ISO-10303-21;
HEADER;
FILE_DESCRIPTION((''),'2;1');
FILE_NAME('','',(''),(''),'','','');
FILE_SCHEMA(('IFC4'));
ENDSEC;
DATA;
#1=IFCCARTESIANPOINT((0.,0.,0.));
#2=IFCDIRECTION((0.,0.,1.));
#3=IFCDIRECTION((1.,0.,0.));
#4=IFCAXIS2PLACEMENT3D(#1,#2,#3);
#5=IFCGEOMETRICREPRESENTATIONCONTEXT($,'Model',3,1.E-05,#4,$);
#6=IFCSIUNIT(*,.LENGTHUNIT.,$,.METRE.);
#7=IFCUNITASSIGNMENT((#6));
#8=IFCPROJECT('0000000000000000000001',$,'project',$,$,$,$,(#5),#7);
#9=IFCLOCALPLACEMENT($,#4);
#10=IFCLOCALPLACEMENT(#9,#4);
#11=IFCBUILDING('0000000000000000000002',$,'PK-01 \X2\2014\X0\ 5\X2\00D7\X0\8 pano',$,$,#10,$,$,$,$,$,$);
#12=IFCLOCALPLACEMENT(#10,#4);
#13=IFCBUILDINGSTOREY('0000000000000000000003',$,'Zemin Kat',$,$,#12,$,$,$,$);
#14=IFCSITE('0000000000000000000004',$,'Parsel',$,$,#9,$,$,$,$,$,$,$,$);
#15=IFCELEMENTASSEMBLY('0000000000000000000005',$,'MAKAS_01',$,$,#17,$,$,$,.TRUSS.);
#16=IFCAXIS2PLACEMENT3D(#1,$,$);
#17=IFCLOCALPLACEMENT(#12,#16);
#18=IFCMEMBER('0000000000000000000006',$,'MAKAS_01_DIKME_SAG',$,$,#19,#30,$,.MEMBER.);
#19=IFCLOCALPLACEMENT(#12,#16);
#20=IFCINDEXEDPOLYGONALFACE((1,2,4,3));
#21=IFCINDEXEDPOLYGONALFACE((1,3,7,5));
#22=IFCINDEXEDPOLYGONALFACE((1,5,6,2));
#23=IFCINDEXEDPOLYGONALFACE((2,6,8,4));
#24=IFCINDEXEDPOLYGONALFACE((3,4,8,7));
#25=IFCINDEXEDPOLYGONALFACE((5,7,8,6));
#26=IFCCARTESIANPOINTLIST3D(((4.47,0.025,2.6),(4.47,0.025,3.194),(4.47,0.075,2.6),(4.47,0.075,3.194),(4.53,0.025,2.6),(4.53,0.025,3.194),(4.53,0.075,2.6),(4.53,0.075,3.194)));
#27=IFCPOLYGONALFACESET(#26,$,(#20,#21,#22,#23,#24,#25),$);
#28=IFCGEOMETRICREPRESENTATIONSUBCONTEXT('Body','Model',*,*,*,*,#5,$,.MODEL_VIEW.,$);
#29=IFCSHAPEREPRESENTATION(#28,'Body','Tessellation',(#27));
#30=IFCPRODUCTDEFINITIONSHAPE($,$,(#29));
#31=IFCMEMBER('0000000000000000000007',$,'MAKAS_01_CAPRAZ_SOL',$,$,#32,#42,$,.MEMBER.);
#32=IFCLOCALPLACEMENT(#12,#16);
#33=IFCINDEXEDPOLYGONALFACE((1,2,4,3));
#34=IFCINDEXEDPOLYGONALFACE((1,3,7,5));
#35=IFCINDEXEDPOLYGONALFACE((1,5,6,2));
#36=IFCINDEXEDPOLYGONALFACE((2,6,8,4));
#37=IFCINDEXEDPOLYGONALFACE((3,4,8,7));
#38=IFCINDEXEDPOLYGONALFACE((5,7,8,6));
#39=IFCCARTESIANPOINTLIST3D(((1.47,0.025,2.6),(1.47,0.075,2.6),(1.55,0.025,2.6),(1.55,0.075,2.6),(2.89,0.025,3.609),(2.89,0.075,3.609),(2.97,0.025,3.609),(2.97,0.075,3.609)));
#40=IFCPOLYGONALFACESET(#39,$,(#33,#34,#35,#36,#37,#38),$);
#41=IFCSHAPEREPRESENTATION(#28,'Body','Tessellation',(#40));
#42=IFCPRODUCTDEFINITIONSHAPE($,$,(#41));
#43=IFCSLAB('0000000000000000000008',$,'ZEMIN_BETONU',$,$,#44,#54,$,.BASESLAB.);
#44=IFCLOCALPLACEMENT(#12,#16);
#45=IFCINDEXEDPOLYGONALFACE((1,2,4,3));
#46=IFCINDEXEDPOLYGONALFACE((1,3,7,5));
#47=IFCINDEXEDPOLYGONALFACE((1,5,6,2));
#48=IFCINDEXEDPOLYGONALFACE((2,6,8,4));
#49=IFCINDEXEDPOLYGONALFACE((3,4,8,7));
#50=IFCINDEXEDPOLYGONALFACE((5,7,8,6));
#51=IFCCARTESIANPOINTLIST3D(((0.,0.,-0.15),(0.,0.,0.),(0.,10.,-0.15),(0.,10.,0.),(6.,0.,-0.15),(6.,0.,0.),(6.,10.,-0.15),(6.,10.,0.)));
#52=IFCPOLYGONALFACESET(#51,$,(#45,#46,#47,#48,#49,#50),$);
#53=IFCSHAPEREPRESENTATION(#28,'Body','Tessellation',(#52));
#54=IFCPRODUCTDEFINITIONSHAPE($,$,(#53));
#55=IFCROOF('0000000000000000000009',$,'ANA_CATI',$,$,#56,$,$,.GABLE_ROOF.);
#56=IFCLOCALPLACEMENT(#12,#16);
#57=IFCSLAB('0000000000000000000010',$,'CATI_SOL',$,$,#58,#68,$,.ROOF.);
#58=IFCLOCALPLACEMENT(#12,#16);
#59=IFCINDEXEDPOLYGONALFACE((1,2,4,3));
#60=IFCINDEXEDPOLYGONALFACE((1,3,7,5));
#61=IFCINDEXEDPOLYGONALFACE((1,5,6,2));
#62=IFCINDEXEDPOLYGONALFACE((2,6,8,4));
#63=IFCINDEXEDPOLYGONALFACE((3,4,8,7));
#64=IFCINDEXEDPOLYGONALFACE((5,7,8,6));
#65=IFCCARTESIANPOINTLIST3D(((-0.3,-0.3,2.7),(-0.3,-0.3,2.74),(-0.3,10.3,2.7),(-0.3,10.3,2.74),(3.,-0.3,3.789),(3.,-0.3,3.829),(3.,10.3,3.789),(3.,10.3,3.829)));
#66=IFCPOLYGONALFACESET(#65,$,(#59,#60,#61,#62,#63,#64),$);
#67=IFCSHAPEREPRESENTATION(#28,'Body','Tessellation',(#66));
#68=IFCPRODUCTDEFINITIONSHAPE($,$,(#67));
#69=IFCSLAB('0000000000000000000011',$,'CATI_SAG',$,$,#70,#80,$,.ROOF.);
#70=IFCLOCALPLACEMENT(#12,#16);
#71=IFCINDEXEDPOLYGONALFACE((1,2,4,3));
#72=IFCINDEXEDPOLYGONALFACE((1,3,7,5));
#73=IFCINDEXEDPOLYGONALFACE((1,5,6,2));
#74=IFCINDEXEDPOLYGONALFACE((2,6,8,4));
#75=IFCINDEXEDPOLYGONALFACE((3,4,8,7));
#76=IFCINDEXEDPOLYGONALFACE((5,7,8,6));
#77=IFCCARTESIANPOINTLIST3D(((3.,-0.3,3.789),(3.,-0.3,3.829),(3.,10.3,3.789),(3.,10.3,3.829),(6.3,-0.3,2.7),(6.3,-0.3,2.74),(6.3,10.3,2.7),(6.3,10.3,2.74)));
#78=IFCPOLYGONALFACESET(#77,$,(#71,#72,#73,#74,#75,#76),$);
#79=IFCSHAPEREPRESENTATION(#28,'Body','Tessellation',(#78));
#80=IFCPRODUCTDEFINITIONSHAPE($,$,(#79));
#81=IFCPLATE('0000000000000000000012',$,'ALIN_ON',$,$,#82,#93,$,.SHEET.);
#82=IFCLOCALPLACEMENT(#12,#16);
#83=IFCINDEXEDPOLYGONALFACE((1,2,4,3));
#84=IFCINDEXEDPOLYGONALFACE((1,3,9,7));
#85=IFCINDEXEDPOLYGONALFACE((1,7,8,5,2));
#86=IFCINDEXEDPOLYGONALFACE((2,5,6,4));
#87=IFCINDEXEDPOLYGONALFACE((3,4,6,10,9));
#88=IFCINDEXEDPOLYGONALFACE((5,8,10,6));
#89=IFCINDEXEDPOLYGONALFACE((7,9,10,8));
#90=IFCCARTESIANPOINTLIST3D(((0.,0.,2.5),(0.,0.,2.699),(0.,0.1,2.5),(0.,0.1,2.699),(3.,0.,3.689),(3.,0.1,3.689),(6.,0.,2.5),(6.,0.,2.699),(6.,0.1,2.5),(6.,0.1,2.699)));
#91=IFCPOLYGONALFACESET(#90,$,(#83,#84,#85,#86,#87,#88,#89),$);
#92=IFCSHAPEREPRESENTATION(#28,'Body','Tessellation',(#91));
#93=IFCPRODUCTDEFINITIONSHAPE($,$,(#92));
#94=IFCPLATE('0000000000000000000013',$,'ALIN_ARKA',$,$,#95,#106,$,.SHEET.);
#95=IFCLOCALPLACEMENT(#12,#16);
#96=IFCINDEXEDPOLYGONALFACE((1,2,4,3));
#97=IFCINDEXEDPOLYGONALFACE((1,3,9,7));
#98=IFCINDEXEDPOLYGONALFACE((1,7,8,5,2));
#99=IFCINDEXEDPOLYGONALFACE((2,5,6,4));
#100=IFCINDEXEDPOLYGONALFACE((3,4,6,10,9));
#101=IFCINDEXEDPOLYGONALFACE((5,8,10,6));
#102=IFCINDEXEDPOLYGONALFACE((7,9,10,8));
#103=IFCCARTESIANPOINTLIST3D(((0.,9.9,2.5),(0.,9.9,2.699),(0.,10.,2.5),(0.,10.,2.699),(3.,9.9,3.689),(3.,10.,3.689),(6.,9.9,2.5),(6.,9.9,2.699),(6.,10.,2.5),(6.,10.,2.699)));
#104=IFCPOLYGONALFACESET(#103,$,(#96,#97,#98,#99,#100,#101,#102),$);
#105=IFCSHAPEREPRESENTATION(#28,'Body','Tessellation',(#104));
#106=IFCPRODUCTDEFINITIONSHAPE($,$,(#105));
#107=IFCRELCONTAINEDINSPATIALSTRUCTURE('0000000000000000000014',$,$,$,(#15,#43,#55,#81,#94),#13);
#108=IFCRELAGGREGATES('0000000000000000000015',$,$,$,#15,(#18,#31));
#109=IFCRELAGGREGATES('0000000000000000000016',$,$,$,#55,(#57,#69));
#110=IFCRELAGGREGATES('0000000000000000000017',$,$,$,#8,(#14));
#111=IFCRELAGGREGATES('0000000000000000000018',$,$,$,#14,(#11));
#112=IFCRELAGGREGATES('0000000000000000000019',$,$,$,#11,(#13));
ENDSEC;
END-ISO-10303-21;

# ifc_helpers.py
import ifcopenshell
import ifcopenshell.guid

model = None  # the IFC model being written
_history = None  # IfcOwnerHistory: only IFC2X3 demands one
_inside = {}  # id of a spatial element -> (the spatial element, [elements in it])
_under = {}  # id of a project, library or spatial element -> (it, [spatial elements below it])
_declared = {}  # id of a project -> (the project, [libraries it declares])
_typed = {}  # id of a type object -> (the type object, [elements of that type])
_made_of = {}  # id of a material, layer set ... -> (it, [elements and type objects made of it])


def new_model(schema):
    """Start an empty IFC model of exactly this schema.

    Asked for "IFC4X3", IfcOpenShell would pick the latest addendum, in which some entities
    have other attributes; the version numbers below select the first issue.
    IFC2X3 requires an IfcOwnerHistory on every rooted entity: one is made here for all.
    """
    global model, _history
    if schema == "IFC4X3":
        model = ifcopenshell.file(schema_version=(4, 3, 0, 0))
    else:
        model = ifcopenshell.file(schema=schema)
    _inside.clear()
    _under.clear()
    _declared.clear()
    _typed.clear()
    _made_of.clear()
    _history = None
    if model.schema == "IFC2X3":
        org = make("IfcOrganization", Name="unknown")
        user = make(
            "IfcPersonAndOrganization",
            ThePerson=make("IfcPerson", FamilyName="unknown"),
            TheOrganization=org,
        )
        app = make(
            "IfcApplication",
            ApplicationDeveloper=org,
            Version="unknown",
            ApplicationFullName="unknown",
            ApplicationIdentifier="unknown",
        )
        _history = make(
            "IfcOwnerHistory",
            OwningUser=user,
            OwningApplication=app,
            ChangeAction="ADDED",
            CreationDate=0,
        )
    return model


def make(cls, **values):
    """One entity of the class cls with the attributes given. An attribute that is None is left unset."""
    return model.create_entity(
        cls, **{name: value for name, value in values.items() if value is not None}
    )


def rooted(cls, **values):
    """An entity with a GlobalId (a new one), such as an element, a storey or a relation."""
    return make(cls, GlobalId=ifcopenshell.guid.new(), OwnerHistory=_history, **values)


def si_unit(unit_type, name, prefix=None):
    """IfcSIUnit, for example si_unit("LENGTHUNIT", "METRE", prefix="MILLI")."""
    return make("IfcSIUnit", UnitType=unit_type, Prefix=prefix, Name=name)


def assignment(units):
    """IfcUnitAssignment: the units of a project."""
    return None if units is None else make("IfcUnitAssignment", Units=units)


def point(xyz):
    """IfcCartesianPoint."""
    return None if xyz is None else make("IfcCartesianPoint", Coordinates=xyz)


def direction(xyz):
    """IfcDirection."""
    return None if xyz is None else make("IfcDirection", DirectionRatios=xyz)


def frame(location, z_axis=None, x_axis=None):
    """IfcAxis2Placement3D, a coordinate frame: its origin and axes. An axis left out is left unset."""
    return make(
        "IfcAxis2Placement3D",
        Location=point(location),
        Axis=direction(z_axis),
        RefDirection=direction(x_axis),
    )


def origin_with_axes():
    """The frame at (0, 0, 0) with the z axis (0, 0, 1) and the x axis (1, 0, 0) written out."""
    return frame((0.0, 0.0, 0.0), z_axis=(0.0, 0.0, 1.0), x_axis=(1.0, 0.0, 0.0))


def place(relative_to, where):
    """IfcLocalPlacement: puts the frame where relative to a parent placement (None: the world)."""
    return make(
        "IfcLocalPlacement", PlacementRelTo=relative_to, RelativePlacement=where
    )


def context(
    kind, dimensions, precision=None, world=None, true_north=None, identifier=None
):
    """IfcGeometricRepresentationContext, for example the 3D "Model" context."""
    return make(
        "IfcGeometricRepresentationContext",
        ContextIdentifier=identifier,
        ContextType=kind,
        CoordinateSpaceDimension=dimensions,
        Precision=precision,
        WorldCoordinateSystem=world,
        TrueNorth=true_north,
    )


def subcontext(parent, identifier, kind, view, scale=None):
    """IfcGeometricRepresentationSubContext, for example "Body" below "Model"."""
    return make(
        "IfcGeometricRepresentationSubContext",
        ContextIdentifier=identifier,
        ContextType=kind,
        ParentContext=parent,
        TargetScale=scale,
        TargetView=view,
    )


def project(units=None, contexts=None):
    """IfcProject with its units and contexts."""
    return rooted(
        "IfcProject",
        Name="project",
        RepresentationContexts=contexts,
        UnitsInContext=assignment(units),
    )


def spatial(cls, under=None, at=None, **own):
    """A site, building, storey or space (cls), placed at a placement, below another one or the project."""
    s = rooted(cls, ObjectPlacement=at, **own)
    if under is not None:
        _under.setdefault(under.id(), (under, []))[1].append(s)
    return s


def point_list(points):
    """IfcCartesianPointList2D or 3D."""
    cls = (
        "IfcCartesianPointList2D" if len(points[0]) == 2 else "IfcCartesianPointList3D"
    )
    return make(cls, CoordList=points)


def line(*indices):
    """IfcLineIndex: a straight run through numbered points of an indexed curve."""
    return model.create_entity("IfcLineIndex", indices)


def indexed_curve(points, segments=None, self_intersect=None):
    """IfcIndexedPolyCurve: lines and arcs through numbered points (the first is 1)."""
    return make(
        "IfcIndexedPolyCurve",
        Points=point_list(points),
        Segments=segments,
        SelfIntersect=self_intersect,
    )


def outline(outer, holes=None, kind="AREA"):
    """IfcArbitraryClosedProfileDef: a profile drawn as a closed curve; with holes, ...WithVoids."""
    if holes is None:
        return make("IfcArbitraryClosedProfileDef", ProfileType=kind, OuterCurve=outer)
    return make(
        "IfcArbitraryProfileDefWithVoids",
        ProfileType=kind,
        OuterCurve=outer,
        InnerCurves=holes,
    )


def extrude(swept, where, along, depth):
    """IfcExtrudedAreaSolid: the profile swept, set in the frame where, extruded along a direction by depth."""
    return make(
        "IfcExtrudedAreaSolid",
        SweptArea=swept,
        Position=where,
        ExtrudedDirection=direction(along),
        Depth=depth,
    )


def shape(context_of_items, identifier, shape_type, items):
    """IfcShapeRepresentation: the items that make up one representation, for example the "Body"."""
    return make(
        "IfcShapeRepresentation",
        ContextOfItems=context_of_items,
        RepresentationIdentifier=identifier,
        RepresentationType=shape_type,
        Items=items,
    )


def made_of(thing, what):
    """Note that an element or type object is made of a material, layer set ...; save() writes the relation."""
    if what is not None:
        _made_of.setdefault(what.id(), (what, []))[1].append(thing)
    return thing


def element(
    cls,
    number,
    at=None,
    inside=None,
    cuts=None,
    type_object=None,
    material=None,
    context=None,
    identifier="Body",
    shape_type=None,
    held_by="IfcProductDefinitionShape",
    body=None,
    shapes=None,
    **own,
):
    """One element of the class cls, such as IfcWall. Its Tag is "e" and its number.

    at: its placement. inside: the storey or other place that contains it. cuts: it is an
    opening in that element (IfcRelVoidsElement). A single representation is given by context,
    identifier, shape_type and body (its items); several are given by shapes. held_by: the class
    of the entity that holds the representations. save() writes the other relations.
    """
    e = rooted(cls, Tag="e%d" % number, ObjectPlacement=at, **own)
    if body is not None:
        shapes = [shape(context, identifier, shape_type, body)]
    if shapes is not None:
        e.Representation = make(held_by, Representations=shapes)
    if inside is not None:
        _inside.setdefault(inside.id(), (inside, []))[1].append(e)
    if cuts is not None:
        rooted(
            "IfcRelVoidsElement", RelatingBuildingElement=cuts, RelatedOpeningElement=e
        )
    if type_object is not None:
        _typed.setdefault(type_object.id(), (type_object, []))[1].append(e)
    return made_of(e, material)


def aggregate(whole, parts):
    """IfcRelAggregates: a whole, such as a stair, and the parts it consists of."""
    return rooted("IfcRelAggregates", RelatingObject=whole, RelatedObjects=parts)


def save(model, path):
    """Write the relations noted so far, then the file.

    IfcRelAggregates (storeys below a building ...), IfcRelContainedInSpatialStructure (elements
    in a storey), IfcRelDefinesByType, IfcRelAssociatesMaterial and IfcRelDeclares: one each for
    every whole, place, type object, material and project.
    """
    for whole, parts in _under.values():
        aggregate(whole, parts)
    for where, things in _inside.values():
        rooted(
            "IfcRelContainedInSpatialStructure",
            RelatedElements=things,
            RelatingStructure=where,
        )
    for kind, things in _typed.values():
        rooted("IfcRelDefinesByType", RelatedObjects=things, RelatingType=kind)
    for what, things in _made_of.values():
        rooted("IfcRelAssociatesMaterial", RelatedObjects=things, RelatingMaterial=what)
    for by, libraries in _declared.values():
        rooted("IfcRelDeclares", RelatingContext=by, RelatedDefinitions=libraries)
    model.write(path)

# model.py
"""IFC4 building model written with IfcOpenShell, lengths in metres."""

from ifc_helpers import new_model, si_unit, frame, origin_with_axes, place, context, subcontext, project, spatial, line, indexed_curve, outline, extrude, element, aggregate, save


model = new_model("IFC4")

# Units and contexts
model_context = context("Model", 3, precision=1e-05, world=origin_with_axes())
body_context = subcontext(model_context, "Body", "Model", "MODEL_VIEW")
ifc_project = project(units=[si_unit("LENGTHUNIT", "METRE")], contexts=[model_context])

# Site, building, storey
site_placement = place(None, origin_with_axes())
site = spatial("IfcSite", under=ifc_project, at=site_placement, Name="Parsel")
building_placement = place(site_placement, origin_with_axes())
building = spatial("IfcBuilding", under=site, at=building_placement, Name="PK-01 — 5×8 pano")
storey_placement = place(building_placement, origin_with_axes())
storey = spatial("IfcBuildingStorey", under=building, at=storey_placement, Name="Zemin Kat")

# Element assembly, members
assembly_placement = place(storey_placement, origin_with_axes())
assembly = element("IfcElementAssembly", 1, at=assembly_placement, inside=storey, Name="MAKAS_01", PredefinedType="TRUSS")
member_1_placement = place(assembly_placement, origin_with_axes())
member_1 = element("IfcMember", 2, at=member_1_placement, Name="MAKAS_01_DIKME_SAG", PredefinedType="MEMBER", context=body_context, shape_type="SweptSolid", body=[
    extrude(outline(indexed_curve([(4.47, 2.6), (4.53, 2.6), (4.53, 3.194), (4.47, 3.194)], segments=[line(1, 2, 3, 4, 1)])), frame((0.0, 0.075, 0.0), z_axis=(0.0, -1.0, 0.0), x_axis=(1.0, 0.0, 0.0)), (0.0, 0.0, 1.0), 0.05),
])
member_2_placement = place(assembly_placement, origin_with_axes())
member_2 = element("IfcMember", 3, at=member_2_placement, Name="MAKAS_01_CAPRAZ_SOL", PredefinedType="MEMBER", context=body_context, shape_type="SweptSolid", body=[
    extrude(outline(indexed_curve([(1.47, 2.6), (1.55, 2.6), (2.97, 3.609), (2.89, 3.609)], segments=[line(1, 2, 3, 4, 1)])), frame((0.0, 0.075, 0.0), z_axis=(0.0, -1.0, 0.0), x_axis=(1.0, 0.0, 0.0)), (0.0, 0.0, 1.0), 0.05),
])
aggregate(assembly, [member_1, member_2])

# Slab
slab_1_placement = place(storey_placement, origin_with_axes())
element("IfcSlab", 4, at=slab_1_placement, inside=storey, Name="ZEMIN_BETONU", PredefinedType="BASESLAB", context=body_context, shape_type="SweptSolid", body=[
    extrude(outline(indexed_curve([(0.0, 0.0), (6.0, 0.0), (6.0, 10.0), (0.0, 10.0)], segments=[line(1, 2, 3, 4, 1)])), frame((0.0, 0.0, -0.15), z_axis=(0.0, 0.0, 1.0), x_axis=(1.0, 0.0, 0.0)), (0.0, 0.0, 1.0), 0.15),
])

# Roof, slabs
roof_placement = place(storey_placement, origin_with_axes())
roof = element("IfcRoof", 5, at=roof_placement, inside=storey, Name="ANA_CATI", PredefinedType="GABLE_ROOF")
slab_2_placement = place(roof_placement, origin_with_axes())
slab_2 = element("IfcSlab", 6, at=slab_2_placement, Name="CATI_SOL", PredefinedType="ROOF", context=body_context, shape_type="SweptSolid", body=[
    extrude(outline(indexed_curve([(-0.3, 2.7), (3.0, 3.789), (3.0, 3.829), (-0.3, 2.74)], segments=[line(1, 2, 3, 4, 1)])), frame((0.0, 10.3, 0.0), z_axis=(0.0, -1.0, 0.0), x_axis=(1.0, 0.0, 0.0)), (0.0, 0.0, 1.0), 10.6),
])
slab_3_placement = place(roof_placement, origin_with_axes())
slab_3 = element("IfcSlab", 7, at=slab_3_placement, Name="CATI_SAG", PredefinedType="ROOF", context=body_context, shape_type="SweptSolid", body=[
    extrude(outline(indexed_curve([(3.0, 3.789), (6.3, 2.7), (6.3, 2.74), (3.0, 3.829)], segments=[line(1, 2, 3, 4, 1)])), frame((0.0, 10.3, 0.0), z_axis=(0.0, -1.0, 0.0), x_axis=(1.0, 0.0, 0.0)), (0.0, 0.0, 1.0), 10.6),
])
aggregate(roof, [slab_2, slab_3])

# Plates
plate_1_placement = place(storey_placement, origin_with_axes())
element("IfcPlate", 8, at=plate_1_placement, inside=storey, Name="ALIN_ON", PredefinedType="SHEET", context=body_context, shape_type="SweptSolid", body=[
    extrude(outline(indexed_curve([(0.0, 2.5), (6.0, 2.5), (6.0, 2.699), (3.0, 3.689), (0.0, 2.699)], segments=[line(1, 2, 3, 4, 5, 1)])), frame((0.0, 0.1, 0.0), z_axis=(0.0, -1.0, 0.0), x_axis=(1.0, 0.0, 0.0)), (0.0, 0.0, 1.0), 0.1),
])
plate_2_placement = place(storey_placement, origin_with_axes())
element("IfcPlate", 9, at=plate_2_placement, inside=storey, Name="ALIN_ARKA", PredefinedType="SHEET", context=body_context, shape_type="SweptSolid", body=[
    extrude(outline(indexed_curve([(0.0, 2.5), (6.0, 2.5), (6.0, 2.699), (3.0, 3.689), (0.0, 2.699)], segments=[line(1, 2, 3, 4, 5, 1)])), frame((0.0, 10.0, 0.0), z_axis=(0.0, -1.0, 0.0), x_axis=(1.0, 0.0, 0.0)), (0.0, 0.0, 1.0), 0.1),
])

save(model, "model.ifc")
